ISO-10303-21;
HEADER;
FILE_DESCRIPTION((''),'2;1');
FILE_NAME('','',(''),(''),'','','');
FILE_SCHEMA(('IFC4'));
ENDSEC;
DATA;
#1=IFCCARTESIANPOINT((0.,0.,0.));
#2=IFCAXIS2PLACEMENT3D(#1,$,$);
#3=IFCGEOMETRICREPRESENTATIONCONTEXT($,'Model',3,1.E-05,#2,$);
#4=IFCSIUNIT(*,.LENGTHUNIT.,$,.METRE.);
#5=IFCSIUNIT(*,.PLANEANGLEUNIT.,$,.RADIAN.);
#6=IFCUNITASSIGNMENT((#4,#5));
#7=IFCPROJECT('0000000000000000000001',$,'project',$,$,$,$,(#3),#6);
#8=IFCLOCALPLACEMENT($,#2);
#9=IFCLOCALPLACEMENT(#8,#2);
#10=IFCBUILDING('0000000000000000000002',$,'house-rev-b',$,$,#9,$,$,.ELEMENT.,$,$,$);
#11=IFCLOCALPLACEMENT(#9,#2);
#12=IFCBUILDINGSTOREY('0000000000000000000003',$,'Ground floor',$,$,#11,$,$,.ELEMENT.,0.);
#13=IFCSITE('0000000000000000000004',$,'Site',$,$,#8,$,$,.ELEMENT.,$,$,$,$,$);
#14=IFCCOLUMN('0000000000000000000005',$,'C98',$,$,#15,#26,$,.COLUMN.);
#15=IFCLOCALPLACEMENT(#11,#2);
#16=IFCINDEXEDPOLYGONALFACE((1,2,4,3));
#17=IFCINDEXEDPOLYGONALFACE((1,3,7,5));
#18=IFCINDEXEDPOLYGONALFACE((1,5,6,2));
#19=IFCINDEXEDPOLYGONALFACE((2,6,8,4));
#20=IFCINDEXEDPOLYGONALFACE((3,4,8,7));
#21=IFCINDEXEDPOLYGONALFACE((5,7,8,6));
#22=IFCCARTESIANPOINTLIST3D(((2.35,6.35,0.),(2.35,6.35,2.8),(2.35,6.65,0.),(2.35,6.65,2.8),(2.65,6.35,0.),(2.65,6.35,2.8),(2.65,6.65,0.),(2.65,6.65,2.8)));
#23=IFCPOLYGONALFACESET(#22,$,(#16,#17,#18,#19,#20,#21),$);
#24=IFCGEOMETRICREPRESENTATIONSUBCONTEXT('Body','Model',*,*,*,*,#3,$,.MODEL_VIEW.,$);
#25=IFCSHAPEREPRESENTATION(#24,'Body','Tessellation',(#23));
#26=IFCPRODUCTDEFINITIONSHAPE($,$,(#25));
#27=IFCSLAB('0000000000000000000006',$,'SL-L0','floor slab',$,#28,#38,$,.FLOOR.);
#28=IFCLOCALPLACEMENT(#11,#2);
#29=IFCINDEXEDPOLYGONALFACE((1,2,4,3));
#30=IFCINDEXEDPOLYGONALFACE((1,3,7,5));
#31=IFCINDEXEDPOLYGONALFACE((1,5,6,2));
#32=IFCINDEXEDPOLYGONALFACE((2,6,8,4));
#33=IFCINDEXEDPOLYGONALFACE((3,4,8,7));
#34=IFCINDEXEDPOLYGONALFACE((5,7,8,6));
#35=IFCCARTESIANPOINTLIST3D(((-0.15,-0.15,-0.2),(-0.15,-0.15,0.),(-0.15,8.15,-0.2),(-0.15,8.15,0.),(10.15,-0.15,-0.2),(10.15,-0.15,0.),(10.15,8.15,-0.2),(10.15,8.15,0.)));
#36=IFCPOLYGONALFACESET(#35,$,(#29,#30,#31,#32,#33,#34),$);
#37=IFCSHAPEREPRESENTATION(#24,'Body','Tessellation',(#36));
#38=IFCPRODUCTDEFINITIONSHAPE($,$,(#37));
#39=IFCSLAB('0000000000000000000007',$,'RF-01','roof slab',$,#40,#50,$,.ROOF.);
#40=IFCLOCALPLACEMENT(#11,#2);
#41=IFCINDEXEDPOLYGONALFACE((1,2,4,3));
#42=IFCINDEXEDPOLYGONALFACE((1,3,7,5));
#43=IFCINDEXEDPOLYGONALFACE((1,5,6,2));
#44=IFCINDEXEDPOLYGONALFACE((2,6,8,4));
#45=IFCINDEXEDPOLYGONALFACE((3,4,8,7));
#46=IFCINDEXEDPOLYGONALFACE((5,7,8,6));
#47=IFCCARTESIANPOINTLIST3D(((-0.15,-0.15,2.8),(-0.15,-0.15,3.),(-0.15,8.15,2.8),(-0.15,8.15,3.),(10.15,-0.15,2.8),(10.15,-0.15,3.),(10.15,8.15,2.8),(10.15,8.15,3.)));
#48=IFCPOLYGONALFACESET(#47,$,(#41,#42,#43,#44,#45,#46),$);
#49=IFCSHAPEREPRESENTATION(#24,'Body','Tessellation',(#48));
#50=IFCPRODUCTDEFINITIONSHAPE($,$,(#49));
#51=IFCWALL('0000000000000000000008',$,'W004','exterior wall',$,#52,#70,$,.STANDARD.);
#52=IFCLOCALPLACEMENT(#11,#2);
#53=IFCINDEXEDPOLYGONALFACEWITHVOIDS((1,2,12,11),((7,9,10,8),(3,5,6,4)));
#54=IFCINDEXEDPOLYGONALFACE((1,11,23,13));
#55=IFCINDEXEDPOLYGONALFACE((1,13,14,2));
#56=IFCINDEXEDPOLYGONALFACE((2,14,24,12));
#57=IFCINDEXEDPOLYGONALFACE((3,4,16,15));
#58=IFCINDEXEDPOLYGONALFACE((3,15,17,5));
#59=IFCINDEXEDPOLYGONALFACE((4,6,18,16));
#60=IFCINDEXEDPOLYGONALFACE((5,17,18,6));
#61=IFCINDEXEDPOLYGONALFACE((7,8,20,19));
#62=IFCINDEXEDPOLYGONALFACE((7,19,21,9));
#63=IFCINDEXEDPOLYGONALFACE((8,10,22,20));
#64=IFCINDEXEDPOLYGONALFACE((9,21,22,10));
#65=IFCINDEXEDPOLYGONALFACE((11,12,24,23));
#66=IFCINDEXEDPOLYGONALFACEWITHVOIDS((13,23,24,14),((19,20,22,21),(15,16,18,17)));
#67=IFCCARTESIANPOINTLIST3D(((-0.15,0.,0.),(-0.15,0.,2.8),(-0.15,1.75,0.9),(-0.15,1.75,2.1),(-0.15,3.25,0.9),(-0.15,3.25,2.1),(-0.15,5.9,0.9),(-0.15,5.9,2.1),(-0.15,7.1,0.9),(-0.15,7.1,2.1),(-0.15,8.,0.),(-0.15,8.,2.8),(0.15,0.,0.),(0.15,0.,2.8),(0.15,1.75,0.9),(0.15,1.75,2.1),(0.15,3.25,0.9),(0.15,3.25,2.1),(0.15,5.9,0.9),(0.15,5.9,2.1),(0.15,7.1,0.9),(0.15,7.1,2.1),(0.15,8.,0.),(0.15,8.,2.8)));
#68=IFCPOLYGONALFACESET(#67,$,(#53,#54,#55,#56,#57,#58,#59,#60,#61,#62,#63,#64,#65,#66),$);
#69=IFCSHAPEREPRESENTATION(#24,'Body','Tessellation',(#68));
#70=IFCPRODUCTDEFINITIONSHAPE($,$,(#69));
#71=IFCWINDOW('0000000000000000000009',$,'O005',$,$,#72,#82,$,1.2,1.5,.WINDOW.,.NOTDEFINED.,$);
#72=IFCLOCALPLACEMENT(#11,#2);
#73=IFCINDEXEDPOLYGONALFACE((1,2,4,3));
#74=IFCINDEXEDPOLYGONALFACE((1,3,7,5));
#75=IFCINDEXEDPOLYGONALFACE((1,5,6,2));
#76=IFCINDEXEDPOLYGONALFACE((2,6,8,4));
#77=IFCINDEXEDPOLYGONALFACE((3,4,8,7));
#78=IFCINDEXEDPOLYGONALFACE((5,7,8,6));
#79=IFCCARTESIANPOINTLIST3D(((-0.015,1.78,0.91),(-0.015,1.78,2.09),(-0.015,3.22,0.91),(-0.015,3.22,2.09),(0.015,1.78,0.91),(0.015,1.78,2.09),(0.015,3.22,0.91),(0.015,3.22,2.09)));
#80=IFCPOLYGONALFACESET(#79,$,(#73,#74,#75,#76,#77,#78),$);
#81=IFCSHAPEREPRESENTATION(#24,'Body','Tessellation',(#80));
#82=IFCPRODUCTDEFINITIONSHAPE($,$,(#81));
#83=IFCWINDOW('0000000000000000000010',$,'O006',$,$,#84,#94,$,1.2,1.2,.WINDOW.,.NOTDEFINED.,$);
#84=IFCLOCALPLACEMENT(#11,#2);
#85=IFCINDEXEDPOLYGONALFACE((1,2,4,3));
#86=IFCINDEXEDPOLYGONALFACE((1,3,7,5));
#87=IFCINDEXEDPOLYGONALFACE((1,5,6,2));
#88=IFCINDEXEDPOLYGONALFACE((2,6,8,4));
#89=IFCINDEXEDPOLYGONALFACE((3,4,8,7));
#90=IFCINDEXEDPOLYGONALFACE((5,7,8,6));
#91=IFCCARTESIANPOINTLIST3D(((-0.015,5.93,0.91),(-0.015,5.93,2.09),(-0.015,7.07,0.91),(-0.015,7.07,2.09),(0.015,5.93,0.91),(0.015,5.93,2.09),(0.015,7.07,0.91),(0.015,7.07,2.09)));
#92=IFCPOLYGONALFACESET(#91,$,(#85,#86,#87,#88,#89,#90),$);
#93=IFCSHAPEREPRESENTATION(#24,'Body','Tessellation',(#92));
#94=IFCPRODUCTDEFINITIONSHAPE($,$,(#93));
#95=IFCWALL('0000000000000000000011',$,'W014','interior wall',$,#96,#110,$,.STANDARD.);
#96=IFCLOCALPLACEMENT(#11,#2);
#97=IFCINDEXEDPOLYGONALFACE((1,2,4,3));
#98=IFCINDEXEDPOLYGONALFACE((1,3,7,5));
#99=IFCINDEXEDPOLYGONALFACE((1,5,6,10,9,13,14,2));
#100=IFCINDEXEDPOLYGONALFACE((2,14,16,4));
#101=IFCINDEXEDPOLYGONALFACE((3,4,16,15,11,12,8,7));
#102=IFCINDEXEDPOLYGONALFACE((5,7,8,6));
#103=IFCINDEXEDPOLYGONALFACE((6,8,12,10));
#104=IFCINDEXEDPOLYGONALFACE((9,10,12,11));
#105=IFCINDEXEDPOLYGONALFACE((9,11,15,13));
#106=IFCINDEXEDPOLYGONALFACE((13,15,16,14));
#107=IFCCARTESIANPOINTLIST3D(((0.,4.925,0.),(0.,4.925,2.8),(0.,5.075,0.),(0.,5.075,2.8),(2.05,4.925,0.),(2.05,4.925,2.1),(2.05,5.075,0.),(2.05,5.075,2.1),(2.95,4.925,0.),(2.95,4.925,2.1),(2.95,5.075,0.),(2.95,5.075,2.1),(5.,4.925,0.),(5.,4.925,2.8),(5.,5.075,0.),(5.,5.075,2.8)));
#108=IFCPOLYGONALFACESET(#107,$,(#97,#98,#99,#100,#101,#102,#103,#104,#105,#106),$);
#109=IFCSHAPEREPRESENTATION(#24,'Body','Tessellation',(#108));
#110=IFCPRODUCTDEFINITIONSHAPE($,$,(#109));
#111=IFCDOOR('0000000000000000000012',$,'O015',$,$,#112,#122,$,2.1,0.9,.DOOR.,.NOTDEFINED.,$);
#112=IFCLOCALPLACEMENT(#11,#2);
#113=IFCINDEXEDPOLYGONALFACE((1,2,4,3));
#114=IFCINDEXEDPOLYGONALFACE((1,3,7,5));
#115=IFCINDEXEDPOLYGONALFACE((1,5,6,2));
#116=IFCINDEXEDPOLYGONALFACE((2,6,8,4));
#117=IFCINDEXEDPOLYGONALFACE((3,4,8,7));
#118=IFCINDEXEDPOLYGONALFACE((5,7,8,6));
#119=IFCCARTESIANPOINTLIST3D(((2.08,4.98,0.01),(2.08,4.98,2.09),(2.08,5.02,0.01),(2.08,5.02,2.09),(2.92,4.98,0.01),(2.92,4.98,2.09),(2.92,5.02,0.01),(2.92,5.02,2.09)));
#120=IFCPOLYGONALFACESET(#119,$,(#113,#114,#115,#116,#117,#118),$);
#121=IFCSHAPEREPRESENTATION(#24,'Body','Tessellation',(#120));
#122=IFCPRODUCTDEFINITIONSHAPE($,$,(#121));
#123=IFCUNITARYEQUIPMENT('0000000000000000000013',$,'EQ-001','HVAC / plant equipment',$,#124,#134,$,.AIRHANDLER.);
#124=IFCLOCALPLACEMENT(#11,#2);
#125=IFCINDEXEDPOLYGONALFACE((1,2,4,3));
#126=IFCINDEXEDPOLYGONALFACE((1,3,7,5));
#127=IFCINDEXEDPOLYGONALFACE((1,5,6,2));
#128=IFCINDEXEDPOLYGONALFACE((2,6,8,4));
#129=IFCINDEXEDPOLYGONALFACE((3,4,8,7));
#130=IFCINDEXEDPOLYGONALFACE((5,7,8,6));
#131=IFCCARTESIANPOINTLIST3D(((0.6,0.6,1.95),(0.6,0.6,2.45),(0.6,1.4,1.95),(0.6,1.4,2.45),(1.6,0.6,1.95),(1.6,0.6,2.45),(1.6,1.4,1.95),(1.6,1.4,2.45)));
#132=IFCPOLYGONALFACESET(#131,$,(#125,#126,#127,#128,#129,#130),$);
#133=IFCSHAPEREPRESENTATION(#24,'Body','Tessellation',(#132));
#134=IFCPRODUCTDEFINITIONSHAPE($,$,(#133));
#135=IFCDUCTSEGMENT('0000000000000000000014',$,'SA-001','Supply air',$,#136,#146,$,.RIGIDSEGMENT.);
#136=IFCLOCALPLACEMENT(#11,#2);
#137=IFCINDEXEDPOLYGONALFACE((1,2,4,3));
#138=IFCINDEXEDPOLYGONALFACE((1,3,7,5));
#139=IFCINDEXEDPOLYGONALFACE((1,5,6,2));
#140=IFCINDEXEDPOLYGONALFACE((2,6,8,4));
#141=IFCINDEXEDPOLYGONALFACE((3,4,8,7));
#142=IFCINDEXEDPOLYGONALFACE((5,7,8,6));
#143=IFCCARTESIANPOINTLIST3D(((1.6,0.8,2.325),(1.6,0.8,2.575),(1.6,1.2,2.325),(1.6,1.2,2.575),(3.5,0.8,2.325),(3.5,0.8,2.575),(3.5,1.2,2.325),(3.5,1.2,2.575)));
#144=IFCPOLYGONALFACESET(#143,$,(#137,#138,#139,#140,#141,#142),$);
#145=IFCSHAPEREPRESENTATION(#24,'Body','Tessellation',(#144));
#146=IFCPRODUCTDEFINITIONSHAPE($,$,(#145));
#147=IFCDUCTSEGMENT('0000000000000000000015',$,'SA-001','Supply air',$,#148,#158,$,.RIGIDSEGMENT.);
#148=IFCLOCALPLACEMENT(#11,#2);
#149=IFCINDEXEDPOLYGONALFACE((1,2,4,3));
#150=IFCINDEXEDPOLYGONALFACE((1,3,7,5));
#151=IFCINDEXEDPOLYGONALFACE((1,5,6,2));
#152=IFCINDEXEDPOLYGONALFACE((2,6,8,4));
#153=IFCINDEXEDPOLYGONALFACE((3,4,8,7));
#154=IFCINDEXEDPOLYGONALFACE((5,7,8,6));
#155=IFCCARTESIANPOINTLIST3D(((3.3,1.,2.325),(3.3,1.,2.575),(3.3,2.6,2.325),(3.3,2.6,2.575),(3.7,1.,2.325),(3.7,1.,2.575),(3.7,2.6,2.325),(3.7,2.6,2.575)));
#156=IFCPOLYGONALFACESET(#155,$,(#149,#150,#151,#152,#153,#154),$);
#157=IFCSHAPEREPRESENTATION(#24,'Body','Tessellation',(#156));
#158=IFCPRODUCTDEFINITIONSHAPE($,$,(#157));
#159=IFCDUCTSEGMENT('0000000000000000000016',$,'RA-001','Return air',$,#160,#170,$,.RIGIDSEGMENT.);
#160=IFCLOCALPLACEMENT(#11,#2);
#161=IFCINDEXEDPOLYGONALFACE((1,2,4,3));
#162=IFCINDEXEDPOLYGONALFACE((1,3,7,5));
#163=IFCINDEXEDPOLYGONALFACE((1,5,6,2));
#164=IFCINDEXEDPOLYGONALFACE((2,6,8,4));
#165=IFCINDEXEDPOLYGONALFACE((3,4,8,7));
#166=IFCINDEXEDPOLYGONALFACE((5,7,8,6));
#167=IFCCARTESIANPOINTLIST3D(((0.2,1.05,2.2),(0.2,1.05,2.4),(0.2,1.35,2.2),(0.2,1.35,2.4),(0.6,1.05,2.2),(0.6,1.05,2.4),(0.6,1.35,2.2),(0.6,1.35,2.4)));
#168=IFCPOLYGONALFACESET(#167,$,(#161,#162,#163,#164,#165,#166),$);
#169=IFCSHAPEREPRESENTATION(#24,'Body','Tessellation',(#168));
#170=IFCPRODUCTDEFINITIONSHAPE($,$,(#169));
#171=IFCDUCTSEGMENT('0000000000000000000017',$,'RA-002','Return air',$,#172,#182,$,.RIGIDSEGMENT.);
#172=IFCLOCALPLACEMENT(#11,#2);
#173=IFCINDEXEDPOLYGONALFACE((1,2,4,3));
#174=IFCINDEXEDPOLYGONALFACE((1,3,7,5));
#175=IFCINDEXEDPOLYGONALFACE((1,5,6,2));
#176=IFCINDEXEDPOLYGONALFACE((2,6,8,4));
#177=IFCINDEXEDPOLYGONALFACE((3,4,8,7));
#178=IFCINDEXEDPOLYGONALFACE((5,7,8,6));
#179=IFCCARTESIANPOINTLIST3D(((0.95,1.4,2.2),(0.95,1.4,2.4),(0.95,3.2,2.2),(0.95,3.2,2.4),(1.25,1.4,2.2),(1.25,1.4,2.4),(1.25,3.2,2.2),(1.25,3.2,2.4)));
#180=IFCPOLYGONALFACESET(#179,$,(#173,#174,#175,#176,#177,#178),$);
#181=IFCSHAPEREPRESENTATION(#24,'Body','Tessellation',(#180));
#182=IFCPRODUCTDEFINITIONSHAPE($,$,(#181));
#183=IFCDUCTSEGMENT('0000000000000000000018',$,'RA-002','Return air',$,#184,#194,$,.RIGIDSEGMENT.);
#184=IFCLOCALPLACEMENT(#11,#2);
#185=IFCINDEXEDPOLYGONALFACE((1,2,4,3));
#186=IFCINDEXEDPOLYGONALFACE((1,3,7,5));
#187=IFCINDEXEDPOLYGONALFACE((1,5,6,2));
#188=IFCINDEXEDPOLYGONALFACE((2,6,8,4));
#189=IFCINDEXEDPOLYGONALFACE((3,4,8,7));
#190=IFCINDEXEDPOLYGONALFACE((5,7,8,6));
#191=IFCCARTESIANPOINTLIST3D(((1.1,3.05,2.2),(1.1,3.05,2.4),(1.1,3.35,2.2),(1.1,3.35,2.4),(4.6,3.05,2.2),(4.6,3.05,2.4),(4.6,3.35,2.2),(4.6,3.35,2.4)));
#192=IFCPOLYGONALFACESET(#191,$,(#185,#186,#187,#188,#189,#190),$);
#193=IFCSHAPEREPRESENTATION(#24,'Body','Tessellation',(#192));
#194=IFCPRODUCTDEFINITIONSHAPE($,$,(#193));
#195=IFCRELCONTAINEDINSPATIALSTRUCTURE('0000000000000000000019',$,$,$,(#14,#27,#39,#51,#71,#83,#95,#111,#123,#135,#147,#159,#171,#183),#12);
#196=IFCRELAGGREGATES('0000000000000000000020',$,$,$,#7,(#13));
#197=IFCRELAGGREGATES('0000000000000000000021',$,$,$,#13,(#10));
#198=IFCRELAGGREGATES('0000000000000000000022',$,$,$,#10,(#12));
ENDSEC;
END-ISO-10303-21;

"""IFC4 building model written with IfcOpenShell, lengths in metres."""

from ifc_helpers import new_model, si_unit, frame, origin, origin_2d, place, context, subcontext, project, spatial, polyline, rectangle, outline, extrude, element, fill, save


model = new_model("IFC4")

# Units and contexts
model_context = context("Model", 3, precision=1e-05, world=origin())
body_context = subcontext(model_context, "Body", "Model", "MODEL_VIEW")
ifc_project = project(units=[si_unit("LENGTHUNIT", "METRE"), si_unit("PLANEANGLEUNIT", "RADIAN")], contexts=[model_context])

# Site, building, storey
site_placement = place(None, origin())
site = spatial("IfcSite", under=ifc_project, at=site_placement, Name="Site", CompositionType="ELEMENT")
building_placement = place(site_placement, origin())
building = spatial("IfcBuilding", under=site, at=building_placement, Name="house-rev-b", CompositionType="ELEMENT")
storey_placement = place(building_placement, origin())
storey = spatial("IfcBuildingStorey", under=building, at=storey_placement, Name="Ground floor", CompositionType="ELEMENT", Elevation=0.0)

# Column
column_placement = place(storey_placement, frame((2.5, 6.5, 0.0)))
element("IfcColumn", 1, at=column_placement, inside=storey, Name="C98", PredefinedType="COLUMN", context=body_context, shape_type="SweptSolid", body=[
    extrude(rectangle(XDim=0.3, YDim=0.3, at=origin_2d()), origin(), (0.0, 0.0, 1.0), 2.8),
])

# Slabs
slab_1_placement = place(storey_placement, frame((0.0, 0.0, -0.2)))
element("IfcSlab", 2, at=slab_1_placement, inside=storey, Name="SL-L0", Description="floor slab", PredefinedType="FLOOR", context=body_context, shape_type="SweptSolid", body=[
    extrude(outline(polyline([(-0.15, 8.15), (10.15, 8.15), (10.15, -0.15), (-0.15, -0.15), (-0.15, 8.15)])), origin(), (0.0, 0.0, 1.0), 0.2),
])
slab_2_placement = place(storey_placement, frame((0.0, 0.0, 2.8)))
element("IfcSlab", 3, at=slab_2_placement, inside=storey, Name="RF-01", Description="roof slab", PredefinedType="ROOF", context=body_context, shape_type="SweptSolid", body=[
    extrude(outline(polyline([(-0.15, 8.15), (10.15, 8.15), (10.15, -0.15), (-0.15, -0.15), (-0.15, 8.15)])), origin(), (0.0, 0.0, 1.0), 0.2),
])

# Wall, openings, windows
wall_1_placement = place(storey_placement, frame((0.0, 4.0, 0.0), z_axis=(0.0, 0.0, 1.0), x_axis=(0.0, 1.0, 0.0)))
wall_1 = element("IfcWall", 4, at=wall_1_placement, inside=storey, Name="W004", Description="exterior wall", PredefinedType="STANDARD", context=body_context, shape_type="SweptSolid", body=[
    extrude(rectangle(XDim=8.0, YDim=0.3, at=origin_2d()), origin(), (0.0, 0.0, 1.0), 2.8),
])
opening_1_placement = place(wall_1_placement, frame((-1.5, 0.0, 0.9)))
opening_1 = element("IfcOpeningElement", 5, at=opening_1_placement, cuts=wall_1, PredefinedType="OPENING", context=body_context, shape_type="SweptSolid", body=[
    extrude(rectangle(XDim=1.5, YDim=0.36, at=origin_2d()), origin(), (0.0, 0.0, 1.0), 1.2),
])
opening_2_placement = place(wall_1_placement, frame((2.5, 0.0, 0.9)))
opening_2 = element("IfcOpeningElement", 6, at=opening_2_placement, cuts=wall_1, PredefinedType="OPENING", context=body_context, shape_type="SweptSolid", body=[
    extrude(rectangle(XDim=1.2, YDim=0.36, at=origin_2d()), origin(), (0.0, 0.0, 1.0), 1.2),
])
window_1_placement = place(wall_1_placement, frame((-1.5, 0.0, 0.9)))
window_1 = element("IfcWindow", 7, at=window_1_placement, inside=storey, Name="O005", OverallHeight=1.2, OverallWidth=1.5, PartitioningType="NOTDEFINED", PredefinedType="WINDOW", context=body_context, shape_type="SweptSolid", body=[
    extrude(rectangle(XDim=1.44, YDim=0.03, at=origin_2d()), frame((0.0, 0.0, 0.01)), (0.0, 0.0, 1.0), 1.18),
])
fill(opening_1, window_1)
window_2_placement = place(wall_1_placement, frame((2.5, 0.0, 0.9)))
window_2 = element("IfcWindow", 8, at=window_2_placement, inside=storey, Name="O006", OverallHeight=1.2, OverallWidth=1.2, PartitioningType="NOTDEFINED", PredefinedType="WINDOW", context=body_context, shape_type="SweptSolid", body=[
    extrude(rectangle(XDim=1.14, YDim=0.03, at=origin_2d()), frame((0.0, 0.0, 0.01)), (0.0, 0.0, 1.0), 1.18),
])
fill(opening_2, window_2)

# Wall, opening, door
wall_2_placement = place(storey_placement, frame((2.5, 5.0, 0.0), z_axis=(0.0, 0.0, 1.0), x_axis=(1.0, 0.0, 0.0)))
wall_2 = element("IfcWall", 9, at=wall_2_placement, inside=storey, Name="W014", Description="interior wall", PredefinedType="STANDARD", context=body_context, shape_type="SweptSolid", body=[
    extrude(rectangle(XDim=5.0, YDim=0.15, at=origin_2d()), origin(), (0.0, 0.0, 1.0), 2.8),
])
opening_3_placement = place(wall_2_placement, origin())
opening_3 = element("IfcOpeningElement", 10, at=opening_3_placement, cuts=wall_2, PredefinedType="OPENING", context=body_context, shape_type="SweptSolid", body=[
    extrude(rectangle(XDim=0.9, YDim=0.18, at=origin_2d()), origin(), (0.0, 0.0, 1.0), 2.1),
])
door_placement = place(wall_2_placement, origin())
door = element("IfcDoor", 11, at=door_placement, inside=storey, Name="O015", OperationType="NOTDEFINED", OverallHeight=2.1, OverallWidth=0.9, PredefinedType="DOOR", context=body_context, shape_type="SweptSolid", body=[
    extrude(rectangle(XDim=0.84, YDim=0.04, at=origin_2d()), frame((0.0, 0.0, 0.01)), (0.0, 0.0, 1.0), 2.08),
])
fill(opening_3, door)

# Unitary equipment
unitary_equipment_placement = place(storey_placement, frame((1.1, 1.0, 1.95), z_axis=(0.0, 0.0, 1.0), x_axis=(1.0, 0.0, 0.0)))
element("IfcUnitaryEquipment", 12, at=unitary_equipment_placement, inside=storey, Name="EQ-001", Description="HVAC / plant equipment", PredefinedType="AIRHANDLER", context=body_context, shape_type="SweptSolid", body=[
    extrude(rectangle(XDim=1.0, YDim=0.8, at=origin_2d()), origin(), (0.0, 0.0, 1.0), 0.5),
])

# Duct segments
duct_segment_1_placement = place(storey_placement, frame((1.6, 1.0, 2.45), z_axis=(1.0, 0.0, 0.0), x_axis=(0.0, 1.0, 0.0)))
element("IfcDuctSegment", 13, at=duct_segment_1_placement, inside=storey, Name="SA-001", Description="Supply air", PredefinedType="RIGIDSEGMENT", context=body_context, shape_type="SweptSolid", body=[
    extrude(rectangle(XDim=0.4, YDim=0.25, at=origin_2d()), origin(), (0.0, 0.0, 1.0), 1.9),
])
duct_segment_2_placement = place(storey_placement, frame((3.5, 1.0, 2.45), z_axis=(0.0, 1.0, 0.0), x_axis=(-1.0, 0.0, 0.0)))
element("IfcDuctSegment", 14, at=duct_segment_2_placement, inside=storey, Name="SA-001", Description="Supply air", PredefinedType="RIGIDSEGMENT", context=body_context, shape_type="SweptSolid", body=[
    extrude(rectangle(XDim=0.4, YDim=0.25, at=origin_2d()), origin(), (0.0, 0.0, 1.0), 1.6),
])
duct_segment_3_placement = place(storey_placement, frame((0.6, 1.2, 2.3), z_axis=(-1.0, 0.0, 0.0), x_axis=(0.0, -1.0, 0.0)))
element("IfcDuctSegment", 15, at=duct_segment_3_placement, inside=storey, Name="RA-001", Description="Return air", PredefinedType="RIGIDSEGMENT", context=body_context, shape_type="SweptSolid", body=[
    extrude(rectangle(XDim=0.3, YDim=0.2, at=origin_2d()), origin(), (0.0, 0.0, 1.0), 0.4),
])
duct_segment_4_placement = place(storey_placement, frame((1.1, 1.4, 2.3), z_axis=(0.0, 1.0, 0.0), x_axis=(-1.0, 0.0, 0.0)))
element("IfcDuctSegment", 16, at=duct_segment_4_placement, inside=storey, Name="RA-002", Description="Return air", PredefinedType="RIGIDSEGMENT", context=body_context, shape_type="SweptSolid", body=[
    extrude(rectangle(XDim=0.3, YDim=0.2, at=origin_2d()), origin(), (0.0, 0.0, 1.0), 1.8),
])
duct_segment_5_placement = place(storey_placement, frame((1.1, 3.2, 2.3), z_axis=(1.0, 0.0, 0.0), x_axis=(0.0, 1.0, 0.0)))
element("IfcDuctSegment", 17, at=duct_segment_5_placement, inside=storey, Name="RA-002", Description="Return air", PredefinedType="RIGIDSEGMENT", context=body_context, shape_type="SweptSolid", body=[
    extrude(rectangle(XDim=0.3, YDim=0.2, at=origin_2d()), origin(), (0.0, 0.0, 1.0), 3.5),
])

save(model, "model.ifc")
